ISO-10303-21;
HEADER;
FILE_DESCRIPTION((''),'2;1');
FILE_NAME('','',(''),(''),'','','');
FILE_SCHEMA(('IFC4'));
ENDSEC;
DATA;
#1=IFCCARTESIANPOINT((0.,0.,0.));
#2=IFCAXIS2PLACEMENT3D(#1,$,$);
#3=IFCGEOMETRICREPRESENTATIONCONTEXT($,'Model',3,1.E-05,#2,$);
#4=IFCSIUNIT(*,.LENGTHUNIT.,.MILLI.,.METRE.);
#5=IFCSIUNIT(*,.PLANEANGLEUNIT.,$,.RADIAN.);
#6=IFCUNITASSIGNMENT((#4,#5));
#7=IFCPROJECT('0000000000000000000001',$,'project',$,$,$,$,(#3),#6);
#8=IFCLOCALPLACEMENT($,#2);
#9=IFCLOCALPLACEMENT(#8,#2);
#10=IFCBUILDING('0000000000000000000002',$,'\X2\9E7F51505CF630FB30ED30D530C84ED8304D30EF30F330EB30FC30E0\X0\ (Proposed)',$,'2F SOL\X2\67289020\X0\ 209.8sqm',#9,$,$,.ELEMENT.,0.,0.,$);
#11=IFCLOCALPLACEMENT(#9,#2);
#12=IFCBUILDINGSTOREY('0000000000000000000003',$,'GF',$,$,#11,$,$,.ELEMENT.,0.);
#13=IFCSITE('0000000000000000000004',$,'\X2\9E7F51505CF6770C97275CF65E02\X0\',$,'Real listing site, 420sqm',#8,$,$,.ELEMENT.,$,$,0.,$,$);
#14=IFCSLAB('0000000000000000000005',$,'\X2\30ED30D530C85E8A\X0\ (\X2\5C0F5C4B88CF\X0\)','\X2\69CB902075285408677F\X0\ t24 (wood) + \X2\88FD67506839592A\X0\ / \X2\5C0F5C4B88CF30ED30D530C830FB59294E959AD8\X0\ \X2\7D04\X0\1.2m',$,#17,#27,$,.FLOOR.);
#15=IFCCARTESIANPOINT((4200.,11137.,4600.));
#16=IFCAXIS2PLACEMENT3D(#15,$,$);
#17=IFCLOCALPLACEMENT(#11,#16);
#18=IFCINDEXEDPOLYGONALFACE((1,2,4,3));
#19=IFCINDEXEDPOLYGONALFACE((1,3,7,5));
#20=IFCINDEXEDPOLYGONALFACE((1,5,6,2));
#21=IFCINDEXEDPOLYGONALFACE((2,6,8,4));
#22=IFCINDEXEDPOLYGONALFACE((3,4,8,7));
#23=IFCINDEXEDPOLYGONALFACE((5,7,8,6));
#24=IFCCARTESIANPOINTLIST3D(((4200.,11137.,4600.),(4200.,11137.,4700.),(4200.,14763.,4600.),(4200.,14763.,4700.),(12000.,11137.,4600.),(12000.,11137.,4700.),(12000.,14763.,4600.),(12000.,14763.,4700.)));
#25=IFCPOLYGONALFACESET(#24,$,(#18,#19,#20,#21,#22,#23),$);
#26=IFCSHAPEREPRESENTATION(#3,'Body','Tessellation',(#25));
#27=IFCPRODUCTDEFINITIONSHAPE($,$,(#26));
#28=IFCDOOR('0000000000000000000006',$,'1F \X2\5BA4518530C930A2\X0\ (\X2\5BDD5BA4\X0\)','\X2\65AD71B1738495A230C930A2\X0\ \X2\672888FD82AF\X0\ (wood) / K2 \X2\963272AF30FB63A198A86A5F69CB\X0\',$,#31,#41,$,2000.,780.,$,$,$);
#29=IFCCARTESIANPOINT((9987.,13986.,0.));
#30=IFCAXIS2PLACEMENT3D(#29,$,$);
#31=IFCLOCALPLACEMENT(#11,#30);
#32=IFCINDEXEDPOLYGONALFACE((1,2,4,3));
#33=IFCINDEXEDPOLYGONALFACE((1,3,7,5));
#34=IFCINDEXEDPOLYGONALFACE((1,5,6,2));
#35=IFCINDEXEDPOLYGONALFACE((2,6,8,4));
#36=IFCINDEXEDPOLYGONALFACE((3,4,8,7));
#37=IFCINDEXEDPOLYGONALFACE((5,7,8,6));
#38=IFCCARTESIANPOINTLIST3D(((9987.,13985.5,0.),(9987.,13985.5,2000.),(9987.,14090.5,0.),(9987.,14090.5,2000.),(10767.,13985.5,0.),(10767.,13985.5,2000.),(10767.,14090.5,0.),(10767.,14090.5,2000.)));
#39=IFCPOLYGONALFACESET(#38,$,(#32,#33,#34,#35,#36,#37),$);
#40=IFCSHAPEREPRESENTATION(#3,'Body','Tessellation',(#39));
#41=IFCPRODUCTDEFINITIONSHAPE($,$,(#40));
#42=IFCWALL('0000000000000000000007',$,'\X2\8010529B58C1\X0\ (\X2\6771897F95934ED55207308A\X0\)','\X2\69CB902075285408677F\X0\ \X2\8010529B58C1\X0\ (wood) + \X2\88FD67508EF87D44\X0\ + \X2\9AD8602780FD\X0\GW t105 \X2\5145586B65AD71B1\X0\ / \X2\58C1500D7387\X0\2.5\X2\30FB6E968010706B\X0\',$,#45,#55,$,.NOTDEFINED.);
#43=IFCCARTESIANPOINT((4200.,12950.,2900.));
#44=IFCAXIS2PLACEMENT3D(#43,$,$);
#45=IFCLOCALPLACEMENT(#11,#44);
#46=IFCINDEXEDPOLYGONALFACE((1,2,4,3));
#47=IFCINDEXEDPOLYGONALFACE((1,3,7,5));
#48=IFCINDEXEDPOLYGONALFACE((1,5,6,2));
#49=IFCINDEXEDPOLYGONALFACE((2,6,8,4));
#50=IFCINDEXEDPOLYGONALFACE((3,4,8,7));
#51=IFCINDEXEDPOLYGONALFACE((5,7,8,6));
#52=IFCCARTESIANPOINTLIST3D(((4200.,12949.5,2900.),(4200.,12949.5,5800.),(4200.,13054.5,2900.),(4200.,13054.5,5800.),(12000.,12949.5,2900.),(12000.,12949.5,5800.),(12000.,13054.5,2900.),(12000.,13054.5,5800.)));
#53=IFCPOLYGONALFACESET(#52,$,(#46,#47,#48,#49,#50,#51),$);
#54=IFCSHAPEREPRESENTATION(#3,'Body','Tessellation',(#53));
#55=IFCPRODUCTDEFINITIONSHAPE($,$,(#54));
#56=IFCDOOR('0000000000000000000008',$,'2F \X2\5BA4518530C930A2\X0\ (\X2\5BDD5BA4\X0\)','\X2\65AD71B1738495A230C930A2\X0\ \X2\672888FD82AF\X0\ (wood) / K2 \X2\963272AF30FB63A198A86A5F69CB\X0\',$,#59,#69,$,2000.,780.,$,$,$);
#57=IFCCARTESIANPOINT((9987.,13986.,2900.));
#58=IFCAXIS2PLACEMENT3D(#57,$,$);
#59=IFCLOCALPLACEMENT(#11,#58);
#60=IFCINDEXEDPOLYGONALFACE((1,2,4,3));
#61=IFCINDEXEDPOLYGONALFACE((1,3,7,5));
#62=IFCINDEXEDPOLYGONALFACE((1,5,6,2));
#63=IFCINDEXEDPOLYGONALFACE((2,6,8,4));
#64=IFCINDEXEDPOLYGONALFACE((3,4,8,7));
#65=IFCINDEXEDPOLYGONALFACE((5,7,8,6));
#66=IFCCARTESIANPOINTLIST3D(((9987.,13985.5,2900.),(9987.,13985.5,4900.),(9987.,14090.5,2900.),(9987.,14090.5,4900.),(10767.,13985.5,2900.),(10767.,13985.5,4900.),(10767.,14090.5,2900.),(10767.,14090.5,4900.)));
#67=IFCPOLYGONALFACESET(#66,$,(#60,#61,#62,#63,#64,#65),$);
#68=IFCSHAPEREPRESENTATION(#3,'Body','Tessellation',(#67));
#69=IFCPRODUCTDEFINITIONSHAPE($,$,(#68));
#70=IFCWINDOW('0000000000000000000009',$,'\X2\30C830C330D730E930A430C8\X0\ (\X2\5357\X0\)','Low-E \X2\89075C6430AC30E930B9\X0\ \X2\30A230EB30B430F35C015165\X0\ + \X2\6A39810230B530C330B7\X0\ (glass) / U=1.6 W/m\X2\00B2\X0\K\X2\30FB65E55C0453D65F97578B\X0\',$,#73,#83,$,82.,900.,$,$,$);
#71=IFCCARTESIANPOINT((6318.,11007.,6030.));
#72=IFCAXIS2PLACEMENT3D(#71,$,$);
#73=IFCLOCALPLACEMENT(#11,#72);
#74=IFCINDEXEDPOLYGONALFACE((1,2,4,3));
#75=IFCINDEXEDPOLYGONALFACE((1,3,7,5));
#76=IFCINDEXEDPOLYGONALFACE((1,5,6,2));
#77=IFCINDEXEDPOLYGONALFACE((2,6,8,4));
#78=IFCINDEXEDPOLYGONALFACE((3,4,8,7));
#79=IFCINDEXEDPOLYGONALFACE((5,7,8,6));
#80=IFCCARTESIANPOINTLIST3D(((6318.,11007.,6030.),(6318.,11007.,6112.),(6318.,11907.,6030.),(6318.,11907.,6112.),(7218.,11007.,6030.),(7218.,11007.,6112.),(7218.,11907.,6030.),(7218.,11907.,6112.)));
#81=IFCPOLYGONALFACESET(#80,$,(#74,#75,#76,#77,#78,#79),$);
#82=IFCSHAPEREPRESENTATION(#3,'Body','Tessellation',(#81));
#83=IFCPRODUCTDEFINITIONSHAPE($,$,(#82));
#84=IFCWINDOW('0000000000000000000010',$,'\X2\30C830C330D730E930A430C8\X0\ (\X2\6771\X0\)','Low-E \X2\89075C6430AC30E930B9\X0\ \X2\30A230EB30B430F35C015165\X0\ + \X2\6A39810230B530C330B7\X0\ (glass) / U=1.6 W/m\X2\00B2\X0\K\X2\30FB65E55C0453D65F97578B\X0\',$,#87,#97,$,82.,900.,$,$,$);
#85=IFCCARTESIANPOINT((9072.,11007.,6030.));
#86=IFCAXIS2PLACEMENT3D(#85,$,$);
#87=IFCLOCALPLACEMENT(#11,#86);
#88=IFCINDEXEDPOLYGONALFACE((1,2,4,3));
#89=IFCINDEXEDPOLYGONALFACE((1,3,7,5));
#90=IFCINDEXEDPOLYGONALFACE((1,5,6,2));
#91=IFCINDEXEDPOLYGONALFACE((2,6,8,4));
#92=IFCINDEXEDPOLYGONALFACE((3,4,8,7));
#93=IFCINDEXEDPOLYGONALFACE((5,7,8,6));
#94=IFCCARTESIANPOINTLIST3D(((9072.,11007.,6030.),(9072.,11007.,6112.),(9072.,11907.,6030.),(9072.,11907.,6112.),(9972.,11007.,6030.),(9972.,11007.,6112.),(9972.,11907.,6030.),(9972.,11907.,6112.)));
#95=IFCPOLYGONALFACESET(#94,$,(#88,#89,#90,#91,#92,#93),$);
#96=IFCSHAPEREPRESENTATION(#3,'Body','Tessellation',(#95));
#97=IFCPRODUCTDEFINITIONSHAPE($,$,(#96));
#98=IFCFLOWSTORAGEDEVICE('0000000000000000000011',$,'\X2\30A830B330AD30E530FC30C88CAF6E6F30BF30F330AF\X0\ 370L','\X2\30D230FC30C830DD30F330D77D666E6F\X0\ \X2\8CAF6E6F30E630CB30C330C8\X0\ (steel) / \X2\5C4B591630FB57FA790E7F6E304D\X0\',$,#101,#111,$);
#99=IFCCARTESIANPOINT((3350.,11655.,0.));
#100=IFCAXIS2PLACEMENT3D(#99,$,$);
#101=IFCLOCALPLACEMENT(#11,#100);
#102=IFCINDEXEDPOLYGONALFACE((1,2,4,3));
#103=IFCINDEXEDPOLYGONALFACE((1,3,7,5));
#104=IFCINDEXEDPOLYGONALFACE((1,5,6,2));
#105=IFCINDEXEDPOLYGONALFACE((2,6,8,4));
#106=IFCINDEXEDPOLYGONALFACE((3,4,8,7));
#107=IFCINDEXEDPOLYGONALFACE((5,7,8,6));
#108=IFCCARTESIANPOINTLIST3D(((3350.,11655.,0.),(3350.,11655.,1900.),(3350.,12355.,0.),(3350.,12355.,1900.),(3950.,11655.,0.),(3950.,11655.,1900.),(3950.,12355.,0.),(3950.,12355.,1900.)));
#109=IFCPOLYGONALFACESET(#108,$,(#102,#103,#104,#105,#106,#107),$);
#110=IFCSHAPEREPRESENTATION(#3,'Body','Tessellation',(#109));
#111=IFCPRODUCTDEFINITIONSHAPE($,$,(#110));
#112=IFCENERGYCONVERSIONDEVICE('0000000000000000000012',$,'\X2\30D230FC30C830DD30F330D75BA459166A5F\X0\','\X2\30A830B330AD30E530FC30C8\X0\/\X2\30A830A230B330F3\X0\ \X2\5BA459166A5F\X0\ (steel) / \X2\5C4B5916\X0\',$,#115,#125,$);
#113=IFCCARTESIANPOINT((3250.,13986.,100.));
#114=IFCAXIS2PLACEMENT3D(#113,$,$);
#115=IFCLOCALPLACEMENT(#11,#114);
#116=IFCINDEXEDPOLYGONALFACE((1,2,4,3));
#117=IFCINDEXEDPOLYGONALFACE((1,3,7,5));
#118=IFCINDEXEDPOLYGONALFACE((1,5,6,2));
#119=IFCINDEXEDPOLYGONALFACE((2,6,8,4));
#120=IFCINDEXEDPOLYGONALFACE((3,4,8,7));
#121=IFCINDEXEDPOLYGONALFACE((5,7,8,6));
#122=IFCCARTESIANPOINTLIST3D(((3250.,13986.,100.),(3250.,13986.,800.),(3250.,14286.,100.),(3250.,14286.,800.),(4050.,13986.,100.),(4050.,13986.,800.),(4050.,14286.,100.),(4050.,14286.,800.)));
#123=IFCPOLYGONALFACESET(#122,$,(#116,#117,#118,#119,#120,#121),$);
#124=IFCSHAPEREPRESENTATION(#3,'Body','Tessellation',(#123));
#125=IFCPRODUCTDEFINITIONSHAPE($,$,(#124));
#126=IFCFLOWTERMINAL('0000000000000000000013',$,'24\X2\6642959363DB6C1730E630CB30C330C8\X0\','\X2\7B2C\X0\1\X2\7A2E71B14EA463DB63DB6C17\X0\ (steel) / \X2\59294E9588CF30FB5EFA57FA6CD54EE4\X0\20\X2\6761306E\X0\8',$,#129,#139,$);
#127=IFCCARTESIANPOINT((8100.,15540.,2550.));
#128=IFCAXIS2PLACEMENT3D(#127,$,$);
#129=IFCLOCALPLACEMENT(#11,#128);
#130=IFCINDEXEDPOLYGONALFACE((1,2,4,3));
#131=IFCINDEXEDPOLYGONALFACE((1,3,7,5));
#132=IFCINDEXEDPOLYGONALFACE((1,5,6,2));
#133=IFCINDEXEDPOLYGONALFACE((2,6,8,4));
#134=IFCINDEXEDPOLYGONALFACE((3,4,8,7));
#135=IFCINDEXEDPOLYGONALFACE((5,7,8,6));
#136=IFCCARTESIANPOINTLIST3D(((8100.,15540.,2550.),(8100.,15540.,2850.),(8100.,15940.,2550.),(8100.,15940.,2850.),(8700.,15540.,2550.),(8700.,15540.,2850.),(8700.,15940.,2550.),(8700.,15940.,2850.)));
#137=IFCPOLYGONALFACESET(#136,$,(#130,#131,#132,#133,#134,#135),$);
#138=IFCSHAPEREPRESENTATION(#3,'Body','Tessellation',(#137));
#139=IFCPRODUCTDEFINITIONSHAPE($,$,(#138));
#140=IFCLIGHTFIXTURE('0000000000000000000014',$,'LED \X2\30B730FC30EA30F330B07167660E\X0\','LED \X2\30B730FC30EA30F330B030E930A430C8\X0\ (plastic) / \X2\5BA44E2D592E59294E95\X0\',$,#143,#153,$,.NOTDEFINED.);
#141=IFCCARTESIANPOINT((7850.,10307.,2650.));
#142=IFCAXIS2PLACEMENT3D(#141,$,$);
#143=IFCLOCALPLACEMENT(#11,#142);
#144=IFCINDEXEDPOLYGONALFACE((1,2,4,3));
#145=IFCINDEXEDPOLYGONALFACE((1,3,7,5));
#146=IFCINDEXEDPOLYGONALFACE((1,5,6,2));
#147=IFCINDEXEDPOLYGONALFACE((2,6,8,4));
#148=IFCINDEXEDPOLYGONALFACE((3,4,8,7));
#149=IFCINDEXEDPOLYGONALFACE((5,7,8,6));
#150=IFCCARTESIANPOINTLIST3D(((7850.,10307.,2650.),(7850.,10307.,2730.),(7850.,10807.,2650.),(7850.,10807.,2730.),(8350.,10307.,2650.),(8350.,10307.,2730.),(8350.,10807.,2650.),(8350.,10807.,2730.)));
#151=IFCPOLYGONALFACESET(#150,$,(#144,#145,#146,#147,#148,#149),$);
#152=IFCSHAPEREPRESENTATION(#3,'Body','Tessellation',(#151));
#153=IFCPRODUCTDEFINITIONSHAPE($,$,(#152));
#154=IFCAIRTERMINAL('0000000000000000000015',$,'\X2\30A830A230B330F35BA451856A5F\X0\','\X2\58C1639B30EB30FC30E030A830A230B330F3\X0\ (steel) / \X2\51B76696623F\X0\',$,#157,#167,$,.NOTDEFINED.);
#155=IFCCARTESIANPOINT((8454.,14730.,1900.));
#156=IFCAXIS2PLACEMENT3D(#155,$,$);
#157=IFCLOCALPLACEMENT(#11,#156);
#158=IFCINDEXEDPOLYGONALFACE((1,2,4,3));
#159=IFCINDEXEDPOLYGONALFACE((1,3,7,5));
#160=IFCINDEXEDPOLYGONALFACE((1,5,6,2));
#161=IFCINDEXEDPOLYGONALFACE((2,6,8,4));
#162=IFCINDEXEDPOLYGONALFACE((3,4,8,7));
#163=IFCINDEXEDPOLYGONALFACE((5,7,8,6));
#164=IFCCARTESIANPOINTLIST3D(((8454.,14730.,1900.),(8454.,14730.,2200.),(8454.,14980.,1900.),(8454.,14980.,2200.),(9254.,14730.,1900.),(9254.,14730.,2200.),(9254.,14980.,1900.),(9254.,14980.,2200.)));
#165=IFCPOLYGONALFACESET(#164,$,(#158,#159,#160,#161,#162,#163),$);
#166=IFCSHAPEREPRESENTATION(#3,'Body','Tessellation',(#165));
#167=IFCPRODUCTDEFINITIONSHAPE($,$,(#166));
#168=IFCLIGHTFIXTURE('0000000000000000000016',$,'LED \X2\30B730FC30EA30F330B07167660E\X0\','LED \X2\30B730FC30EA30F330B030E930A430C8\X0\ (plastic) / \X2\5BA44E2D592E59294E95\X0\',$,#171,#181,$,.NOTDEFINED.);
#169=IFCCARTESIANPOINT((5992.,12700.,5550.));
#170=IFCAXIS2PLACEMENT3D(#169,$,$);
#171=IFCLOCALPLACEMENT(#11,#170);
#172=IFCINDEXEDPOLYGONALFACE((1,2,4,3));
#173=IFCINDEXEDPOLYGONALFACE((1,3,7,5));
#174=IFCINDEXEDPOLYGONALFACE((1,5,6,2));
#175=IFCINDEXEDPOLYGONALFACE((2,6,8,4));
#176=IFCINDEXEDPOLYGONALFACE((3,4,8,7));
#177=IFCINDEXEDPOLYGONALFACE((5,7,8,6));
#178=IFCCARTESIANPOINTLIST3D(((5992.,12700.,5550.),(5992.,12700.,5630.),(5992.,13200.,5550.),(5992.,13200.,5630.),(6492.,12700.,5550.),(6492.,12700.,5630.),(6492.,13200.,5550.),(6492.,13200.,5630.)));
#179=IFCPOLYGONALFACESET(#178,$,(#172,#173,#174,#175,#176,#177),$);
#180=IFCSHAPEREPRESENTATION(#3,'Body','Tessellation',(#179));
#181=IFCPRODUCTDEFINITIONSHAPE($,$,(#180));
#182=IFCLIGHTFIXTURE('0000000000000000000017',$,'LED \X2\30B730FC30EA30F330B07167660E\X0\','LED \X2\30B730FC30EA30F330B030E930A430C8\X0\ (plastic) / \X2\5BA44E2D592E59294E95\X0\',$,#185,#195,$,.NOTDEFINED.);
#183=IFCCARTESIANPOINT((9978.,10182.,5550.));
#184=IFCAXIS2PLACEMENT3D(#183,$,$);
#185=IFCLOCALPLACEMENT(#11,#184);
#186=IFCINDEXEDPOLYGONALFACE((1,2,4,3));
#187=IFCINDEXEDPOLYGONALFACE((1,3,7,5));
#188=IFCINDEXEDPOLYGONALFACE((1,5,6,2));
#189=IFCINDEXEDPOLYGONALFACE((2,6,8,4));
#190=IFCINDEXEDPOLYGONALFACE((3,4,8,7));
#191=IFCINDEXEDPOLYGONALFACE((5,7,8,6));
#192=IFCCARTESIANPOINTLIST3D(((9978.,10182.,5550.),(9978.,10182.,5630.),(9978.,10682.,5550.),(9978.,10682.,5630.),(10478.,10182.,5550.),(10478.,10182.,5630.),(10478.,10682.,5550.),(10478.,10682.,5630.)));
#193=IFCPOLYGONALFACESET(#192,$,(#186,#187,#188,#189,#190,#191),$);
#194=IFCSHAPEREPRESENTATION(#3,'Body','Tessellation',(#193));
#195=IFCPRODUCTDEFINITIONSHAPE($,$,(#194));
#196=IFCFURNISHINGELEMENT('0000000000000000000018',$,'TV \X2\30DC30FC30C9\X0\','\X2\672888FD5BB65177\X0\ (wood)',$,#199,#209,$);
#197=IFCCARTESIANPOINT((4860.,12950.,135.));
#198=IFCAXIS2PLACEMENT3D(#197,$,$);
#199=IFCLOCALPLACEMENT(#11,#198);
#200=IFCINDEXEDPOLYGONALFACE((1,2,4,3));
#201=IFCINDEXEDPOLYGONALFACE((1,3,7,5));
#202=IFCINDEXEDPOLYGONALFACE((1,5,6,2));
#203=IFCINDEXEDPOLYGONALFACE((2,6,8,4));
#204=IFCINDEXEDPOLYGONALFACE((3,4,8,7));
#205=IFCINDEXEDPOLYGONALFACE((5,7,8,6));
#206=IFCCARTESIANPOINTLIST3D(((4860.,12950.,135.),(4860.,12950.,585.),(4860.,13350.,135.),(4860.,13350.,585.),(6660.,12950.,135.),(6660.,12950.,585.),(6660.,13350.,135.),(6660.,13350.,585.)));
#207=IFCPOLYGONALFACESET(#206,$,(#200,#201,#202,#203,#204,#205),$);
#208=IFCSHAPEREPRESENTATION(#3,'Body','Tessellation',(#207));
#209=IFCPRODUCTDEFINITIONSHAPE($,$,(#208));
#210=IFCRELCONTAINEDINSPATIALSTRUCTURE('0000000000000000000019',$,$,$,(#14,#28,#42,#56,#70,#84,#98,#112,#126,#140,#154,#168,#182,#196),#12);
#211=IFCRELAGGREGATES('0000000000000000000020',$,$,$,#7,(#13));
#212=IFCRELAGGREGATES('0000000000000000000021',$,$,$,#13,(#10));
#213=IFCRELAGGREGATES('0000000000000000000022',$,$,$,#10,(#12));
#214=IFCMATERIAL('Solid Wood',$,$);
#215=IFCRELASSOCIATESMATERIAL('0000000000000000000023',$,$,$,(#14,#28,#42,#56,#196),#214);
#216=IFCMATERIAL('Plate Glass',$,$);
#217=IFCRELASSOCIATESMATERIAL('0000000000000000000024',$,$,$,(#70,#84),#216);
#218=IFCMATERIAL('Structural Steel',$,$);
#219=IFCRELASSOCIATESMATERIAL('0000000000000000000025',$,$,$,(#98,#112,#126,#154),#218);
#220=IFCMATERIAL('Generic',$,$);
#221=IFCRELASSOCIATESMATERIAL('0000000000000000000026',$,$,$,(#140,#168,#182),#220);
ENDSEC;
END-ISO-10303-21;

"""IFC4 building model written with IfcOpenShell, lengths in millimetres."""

from ifc_helpers import new_model, si_unit, frame, frame_2d, origin, place, context, project, spatial, rectangle, extrude, material, element, save


model = new_model("IFC4")

# Units and contexts
model_context = context("Model", 3, precision=1e-05, world=origin())
ifc_project = project(units=[si_unit("LENGTHUNIT", "METRE", prefix="MILLI"), si_unit("PLANEANGLEUNIT", "RADIAN")], contexts=[model_context])

# Site, building, storey
site_placement = place(None, origin())
site = spatial("IfcSite", under=ifc_project, at=site_placement, Name="鹿児島県霧島市", ObjectType="Real listing site, 420sqm", CompositionType="ELEMENT", RefElevation=0.0)
building_placement = place(site_placement, origin())
building = spatial("IfcBuilding", under=site, at=building_placement, Name="鹿児島・ロフト付きワンルーム (Proposed)", ObjectType="2F SOL木造 209.8sqm", CompositionType="ELEMENT", ElevationOfRefHeight=0.0, ElevationOfTerrain=0.0)
storey_placement = place(building_placement, origin())
storey = spatial("IfcBuildingStorey", under=building, at=storey_placement, Name="GF", CompositionType="ELEMENT", Elevation=0.0)

# Shared definitions
ifc_material_1 = material(Name="Solid Wood")

# Slab
slab_placement = place(storey_placement, frame((4200.0, 11137.0, 4600.0)))
element("IfcSlab", 1, at=slab_placement, inside=storey, material=ifc_material_1, Name="ロフト床 (小屋裏)", Description="構造用合板 t24 (wood) + 製材根太 / 小屋裏ロフト・天井高 約1.2m", PredefinedType="FLOOR", context=model_context, shape_type="SweptSolid", body=[
    extrude(rectangle(XDim=7800.0, YDim=3626.0, at=frame_2d((3900.0, 1813.0))), frame((4200.0, 11137.0, 4600.0)), (0.0, 0.0, 1.0), 100.0),
])

# Door
door_1_placement = place(storey_placement, frame((9987.0, 13986.0, 0.0)))
element("IfcDoor", 2, at=door_1_placement, inside=storey, material=ifc_material_1, Name="1F 室内ドア (寝室)", Description="断熱玄関ドア 木製芯 (wood) / K2 防犯・採風機構", OverallHeight=2000.0, OverallWidth=780.0, context=model_context, shape_type="SweptSolid", body=[
    extrude(rectangle(XDim=780.0, YDim=105.0, at=frame_2d((390.0, 52.0))), frame((9987.0, 13986.0, 0.0)), (0.0, 0.0, 1.0), 2000.0),
])

# Wall
wall_1_placement = place(storey_placement, frame((4200.0, 12950.0, 2900.0)))
element("IfcWall", 3, at=wall_1_placement, inside=storey, material=ifc_material_1, Name="耐力壁 (東西間仕切り)", Description="構造用合板 耐力壁 (wood) + 製材軸組 + 高性能GW t105 充填断熱 / 壁倍率2.5・準耐火", PredefinedType="NOTDEFINED", context=model_context, shape_type="SweptSolid", body=[
    extrude(rectangle(XDim=7800.0, YDim=105.0, at=frame_2d((3900.0, 52.0))), frame((4200.0, 12950.0, 2900.0)), (0.0, 0.0, 1.0), 2900.0),
])

# Door
door_2_placement = place(storey_placement, frame((9987.0, 13986.0, 2900.0)))
element("IfcDoor", 4, at=door_2_placement, inside=storey, material=ifc_material_1, Name="2F 室内ドア (寝室)", Description="断熱玄関ドア 木製芯 (wood) / K2 防犯・採風機構", OverallHeight=2000.0, OverallWidth=780.0, context=model_context, shape_type="SweptSolid", body=[
    extrude(rectangle(XDim=780.0, YDim=105.0, at=frame_2d((390.0, 52.0))), frame((9987.0, 13986.0, 2900.0)), (0.0, 0.0, 1.0), 2000.0),
])

# Windows
ifc_material_2 = material(Name="Plate Glass")
window_1_placement = place(storey_placement, frame((6318.0, 11007.0, 6030.0)))
element("IfcWindow", 5, at=window_1_placement, inside=storey, material=ifc_material_2, Name="トップライト (南)", Description="Low-E 複層ガラス アルゴン封入 + 樹脂サッシ (glass) / U=1.6 W/m²K・日射取得型", OverallHeight=82.0, OverallWidth=900.0, context=model_context, shape_type="SweptSolid", body=[
    extrude(rectangle(XDim=900.0, YDim=900.0, at=frame_2d((450.0, 450.0))), frame((6318.0, 11007.0, 6030.0)), (0.0, 0.0, 1.0), 82.0),
])
window_2_placement = place(storey_placement, frame((9072.0, 11007.0, 6030.0)))
element("IfcWindow", 6, at=window_2_placement, inside=storey, material=ifc_material_2, Name="トップライト (東)", Description="Low-E 複層ガラス アルゴン封入 + 樹脂サッシ (glass) / U=1.6 W/m²K・日射取得型", OverallHeight=82.0, OverallWidth=900.0, context=model_context, shape_type="SweptSolid", body=[
    extrude(rectangle(XDim=900.0, YDim=900.0, at=frame_2d((450.0, 450.0))), frame((9072.0, 11007.0, 6030.0)), (0.0, 0.0, 1.0), 82.0),
])

# Flow storage device
ifc_material_3 = material(Name="Structural Steel")
flow_storage_device_placement = place(storey_placement, frame((3350.0, 11655.0, 0.0)))
element("IfcFlowStorageDevice", 7, at=flow_storage_device_placement, inside=storey, material=ifc_material_3, Name="エコキュート貯湯タンク 370L", Description="ヒートポンプ給湯 貯湯ユニット (steel) / 屋外・基礎置き", context=model_context, shape_type="SweptSolid", body=[
    extrude(rectangle(XDim=600.0, YDim=700.0, at=frame_2d((300.0, 350.0))), frame((3350.0, 11655.0, 0.0)), (0.0, 0.0, 1.0), 1900.0),
])

# Energy conversion device
energy_conversion_device_placement = place(storey_placement, frame((3250.0, 13986.0, 100.0)))
element("IfcEnergyConversionDevice", 8, at=energy_conversion_device_placement, inside=storey, material=ifc_material_3, Name="ヒートポンプ室外機", Description="エコキュート/エアコン 室外機 (steel) / 屋外", context=model_context, shape_type="SweptSolid", body=[
    extrude(rectangle(XDim=800.0, YDim=300.0, at=frame_2d((400.0, 150.0))), frame((3250.0, 13986.0, 100.0)), (0.0, 0.0, 1.0), 700.0),
])

# Flow terminal
flow_terminal_placement = place(storey_placement, frame((8100.0, 15540.0, 2550.0)))
element("IfcFlowTerminal", 9, at=flow_terminal_placement, inside=storey, material=ifc_material_3, Name="24時間換気ユニット", Description="第1種熱交換換気 (steel) / 天井裏・建基法令20条の8", context=model_context, shape_type="SweptSolid", body=[
    extrude(rectangle(XDim=600.0, YDim=400.0, at=frame_2d((300.0, 200.0))), frame((8100.0, 15540.0, 2550.0)), (0.0, 0.0, 1.0), 300.0),
])

# Light fixture
ifc_material_4 = material(Name="Generic")
light_fixture_1_placement = place(storey_placement, frame((7850.0, 10307.0, 2650.0)))
element("IfcLightFixture", 10, at=light_fixture_1_placement, inside=storey, material=ifc_material_4, Name="LED シーリング照明", Description="LED シーリングライト (plastic) / 室中央天井", PredefinedType="NOTDEFINED", context=model_context, shape_type="SweptSolid", body=[
    extrude(rectangle(XDim=500.0, YDim=500.0, at=frame_2d((250.0, 250.0))), frame((7850.0, 10307.0, 2650.0)), (0.0, 0.0, 1.0), 80.0),
])

# Air terminal
air_terminal_placement = place(storey_placement, frame((8454.0, 14730.0, 1900.0)))
element("IfcAirTerminal", 11, at=air_terminal_placement, inside=storey, material=ifc_material_3, Name="エアコン室内機", Description="壁掛ルームエアコン (steel) / 冷暖房", PredefinedType="NOTDEFINED", context=model_context, shape_type="SweptSolid", body=[
    extrude(rectangle(XDim=800.0, YDim=250.0, at=frame_2d((400.0, 125.0))), frame((8454.0, 14730.0, 1900.0)), (0.0, 0.0, 1.0), 300.0),
])

# Light fixtures
light_fixture_2_placement = place(storey_placement, frame((5992.0, 12700.0, 5550.0)))
element("IfcLightFixture", 12, at=light_fixture_2_placement, inside=storey, material=ifc_material_4, Name="LED シーリング照明", Description="LED シーリングライト (plastic) / 室中央天井", PredefinedType="NOTDEFINED", context=model_context, shape_type="SweptSolid", body=[
    extrude(rectangle(XDim=500.0, YDim=500.0, at=frame_2d((250.0, 250.0))), frame((5992.0, 12700.0, 5550.0)), (0.0, 0.0, 1.0), 80.0),
])
light_fixture_3_placement = place(storey_placement, frame((9978.0, 10182.0, 5550.0)))
element("IfcLightFixture", 13, at=light_fixture_3_placement, inside=storey, material=ifc_material_4, Name="LED シーリング照明", Description="LED シーリングライト (plastic) / 室中央天井", PredefinedType="NOTDEFINED", context=model_context, shape_type="SweptSolid", body=[
    extrude(rectangle(XDim=500.0, YDim=500.0, at=frame_2d((250.0, 250.0))), frame((9978.0, 10182.0, 5550.0)), (0.0, 0.0, 1.0), 80.0),
])

# Furnishing element
furnishing_1_placement = place(storey_placement, frame((4860.0, 12950.0, 135.0)))
element("IfcFurnishingElement", 14, at=furnishing_1_placement, inside=storey, material=ifc_material_1, Name="TV ボード", Description="木製家具 (wood)", context=model_context, shape_type="SweptSolid", body=[
    extrude(rectangle(XDim=1800.0, YDim=400.0, at=frame_2d((900.0, 200.0))), frame((4860.0, 12950.0, 135.0)), (0.0, 0.0, 1.0), 450.0),
])

save(model, "model.ifc")
